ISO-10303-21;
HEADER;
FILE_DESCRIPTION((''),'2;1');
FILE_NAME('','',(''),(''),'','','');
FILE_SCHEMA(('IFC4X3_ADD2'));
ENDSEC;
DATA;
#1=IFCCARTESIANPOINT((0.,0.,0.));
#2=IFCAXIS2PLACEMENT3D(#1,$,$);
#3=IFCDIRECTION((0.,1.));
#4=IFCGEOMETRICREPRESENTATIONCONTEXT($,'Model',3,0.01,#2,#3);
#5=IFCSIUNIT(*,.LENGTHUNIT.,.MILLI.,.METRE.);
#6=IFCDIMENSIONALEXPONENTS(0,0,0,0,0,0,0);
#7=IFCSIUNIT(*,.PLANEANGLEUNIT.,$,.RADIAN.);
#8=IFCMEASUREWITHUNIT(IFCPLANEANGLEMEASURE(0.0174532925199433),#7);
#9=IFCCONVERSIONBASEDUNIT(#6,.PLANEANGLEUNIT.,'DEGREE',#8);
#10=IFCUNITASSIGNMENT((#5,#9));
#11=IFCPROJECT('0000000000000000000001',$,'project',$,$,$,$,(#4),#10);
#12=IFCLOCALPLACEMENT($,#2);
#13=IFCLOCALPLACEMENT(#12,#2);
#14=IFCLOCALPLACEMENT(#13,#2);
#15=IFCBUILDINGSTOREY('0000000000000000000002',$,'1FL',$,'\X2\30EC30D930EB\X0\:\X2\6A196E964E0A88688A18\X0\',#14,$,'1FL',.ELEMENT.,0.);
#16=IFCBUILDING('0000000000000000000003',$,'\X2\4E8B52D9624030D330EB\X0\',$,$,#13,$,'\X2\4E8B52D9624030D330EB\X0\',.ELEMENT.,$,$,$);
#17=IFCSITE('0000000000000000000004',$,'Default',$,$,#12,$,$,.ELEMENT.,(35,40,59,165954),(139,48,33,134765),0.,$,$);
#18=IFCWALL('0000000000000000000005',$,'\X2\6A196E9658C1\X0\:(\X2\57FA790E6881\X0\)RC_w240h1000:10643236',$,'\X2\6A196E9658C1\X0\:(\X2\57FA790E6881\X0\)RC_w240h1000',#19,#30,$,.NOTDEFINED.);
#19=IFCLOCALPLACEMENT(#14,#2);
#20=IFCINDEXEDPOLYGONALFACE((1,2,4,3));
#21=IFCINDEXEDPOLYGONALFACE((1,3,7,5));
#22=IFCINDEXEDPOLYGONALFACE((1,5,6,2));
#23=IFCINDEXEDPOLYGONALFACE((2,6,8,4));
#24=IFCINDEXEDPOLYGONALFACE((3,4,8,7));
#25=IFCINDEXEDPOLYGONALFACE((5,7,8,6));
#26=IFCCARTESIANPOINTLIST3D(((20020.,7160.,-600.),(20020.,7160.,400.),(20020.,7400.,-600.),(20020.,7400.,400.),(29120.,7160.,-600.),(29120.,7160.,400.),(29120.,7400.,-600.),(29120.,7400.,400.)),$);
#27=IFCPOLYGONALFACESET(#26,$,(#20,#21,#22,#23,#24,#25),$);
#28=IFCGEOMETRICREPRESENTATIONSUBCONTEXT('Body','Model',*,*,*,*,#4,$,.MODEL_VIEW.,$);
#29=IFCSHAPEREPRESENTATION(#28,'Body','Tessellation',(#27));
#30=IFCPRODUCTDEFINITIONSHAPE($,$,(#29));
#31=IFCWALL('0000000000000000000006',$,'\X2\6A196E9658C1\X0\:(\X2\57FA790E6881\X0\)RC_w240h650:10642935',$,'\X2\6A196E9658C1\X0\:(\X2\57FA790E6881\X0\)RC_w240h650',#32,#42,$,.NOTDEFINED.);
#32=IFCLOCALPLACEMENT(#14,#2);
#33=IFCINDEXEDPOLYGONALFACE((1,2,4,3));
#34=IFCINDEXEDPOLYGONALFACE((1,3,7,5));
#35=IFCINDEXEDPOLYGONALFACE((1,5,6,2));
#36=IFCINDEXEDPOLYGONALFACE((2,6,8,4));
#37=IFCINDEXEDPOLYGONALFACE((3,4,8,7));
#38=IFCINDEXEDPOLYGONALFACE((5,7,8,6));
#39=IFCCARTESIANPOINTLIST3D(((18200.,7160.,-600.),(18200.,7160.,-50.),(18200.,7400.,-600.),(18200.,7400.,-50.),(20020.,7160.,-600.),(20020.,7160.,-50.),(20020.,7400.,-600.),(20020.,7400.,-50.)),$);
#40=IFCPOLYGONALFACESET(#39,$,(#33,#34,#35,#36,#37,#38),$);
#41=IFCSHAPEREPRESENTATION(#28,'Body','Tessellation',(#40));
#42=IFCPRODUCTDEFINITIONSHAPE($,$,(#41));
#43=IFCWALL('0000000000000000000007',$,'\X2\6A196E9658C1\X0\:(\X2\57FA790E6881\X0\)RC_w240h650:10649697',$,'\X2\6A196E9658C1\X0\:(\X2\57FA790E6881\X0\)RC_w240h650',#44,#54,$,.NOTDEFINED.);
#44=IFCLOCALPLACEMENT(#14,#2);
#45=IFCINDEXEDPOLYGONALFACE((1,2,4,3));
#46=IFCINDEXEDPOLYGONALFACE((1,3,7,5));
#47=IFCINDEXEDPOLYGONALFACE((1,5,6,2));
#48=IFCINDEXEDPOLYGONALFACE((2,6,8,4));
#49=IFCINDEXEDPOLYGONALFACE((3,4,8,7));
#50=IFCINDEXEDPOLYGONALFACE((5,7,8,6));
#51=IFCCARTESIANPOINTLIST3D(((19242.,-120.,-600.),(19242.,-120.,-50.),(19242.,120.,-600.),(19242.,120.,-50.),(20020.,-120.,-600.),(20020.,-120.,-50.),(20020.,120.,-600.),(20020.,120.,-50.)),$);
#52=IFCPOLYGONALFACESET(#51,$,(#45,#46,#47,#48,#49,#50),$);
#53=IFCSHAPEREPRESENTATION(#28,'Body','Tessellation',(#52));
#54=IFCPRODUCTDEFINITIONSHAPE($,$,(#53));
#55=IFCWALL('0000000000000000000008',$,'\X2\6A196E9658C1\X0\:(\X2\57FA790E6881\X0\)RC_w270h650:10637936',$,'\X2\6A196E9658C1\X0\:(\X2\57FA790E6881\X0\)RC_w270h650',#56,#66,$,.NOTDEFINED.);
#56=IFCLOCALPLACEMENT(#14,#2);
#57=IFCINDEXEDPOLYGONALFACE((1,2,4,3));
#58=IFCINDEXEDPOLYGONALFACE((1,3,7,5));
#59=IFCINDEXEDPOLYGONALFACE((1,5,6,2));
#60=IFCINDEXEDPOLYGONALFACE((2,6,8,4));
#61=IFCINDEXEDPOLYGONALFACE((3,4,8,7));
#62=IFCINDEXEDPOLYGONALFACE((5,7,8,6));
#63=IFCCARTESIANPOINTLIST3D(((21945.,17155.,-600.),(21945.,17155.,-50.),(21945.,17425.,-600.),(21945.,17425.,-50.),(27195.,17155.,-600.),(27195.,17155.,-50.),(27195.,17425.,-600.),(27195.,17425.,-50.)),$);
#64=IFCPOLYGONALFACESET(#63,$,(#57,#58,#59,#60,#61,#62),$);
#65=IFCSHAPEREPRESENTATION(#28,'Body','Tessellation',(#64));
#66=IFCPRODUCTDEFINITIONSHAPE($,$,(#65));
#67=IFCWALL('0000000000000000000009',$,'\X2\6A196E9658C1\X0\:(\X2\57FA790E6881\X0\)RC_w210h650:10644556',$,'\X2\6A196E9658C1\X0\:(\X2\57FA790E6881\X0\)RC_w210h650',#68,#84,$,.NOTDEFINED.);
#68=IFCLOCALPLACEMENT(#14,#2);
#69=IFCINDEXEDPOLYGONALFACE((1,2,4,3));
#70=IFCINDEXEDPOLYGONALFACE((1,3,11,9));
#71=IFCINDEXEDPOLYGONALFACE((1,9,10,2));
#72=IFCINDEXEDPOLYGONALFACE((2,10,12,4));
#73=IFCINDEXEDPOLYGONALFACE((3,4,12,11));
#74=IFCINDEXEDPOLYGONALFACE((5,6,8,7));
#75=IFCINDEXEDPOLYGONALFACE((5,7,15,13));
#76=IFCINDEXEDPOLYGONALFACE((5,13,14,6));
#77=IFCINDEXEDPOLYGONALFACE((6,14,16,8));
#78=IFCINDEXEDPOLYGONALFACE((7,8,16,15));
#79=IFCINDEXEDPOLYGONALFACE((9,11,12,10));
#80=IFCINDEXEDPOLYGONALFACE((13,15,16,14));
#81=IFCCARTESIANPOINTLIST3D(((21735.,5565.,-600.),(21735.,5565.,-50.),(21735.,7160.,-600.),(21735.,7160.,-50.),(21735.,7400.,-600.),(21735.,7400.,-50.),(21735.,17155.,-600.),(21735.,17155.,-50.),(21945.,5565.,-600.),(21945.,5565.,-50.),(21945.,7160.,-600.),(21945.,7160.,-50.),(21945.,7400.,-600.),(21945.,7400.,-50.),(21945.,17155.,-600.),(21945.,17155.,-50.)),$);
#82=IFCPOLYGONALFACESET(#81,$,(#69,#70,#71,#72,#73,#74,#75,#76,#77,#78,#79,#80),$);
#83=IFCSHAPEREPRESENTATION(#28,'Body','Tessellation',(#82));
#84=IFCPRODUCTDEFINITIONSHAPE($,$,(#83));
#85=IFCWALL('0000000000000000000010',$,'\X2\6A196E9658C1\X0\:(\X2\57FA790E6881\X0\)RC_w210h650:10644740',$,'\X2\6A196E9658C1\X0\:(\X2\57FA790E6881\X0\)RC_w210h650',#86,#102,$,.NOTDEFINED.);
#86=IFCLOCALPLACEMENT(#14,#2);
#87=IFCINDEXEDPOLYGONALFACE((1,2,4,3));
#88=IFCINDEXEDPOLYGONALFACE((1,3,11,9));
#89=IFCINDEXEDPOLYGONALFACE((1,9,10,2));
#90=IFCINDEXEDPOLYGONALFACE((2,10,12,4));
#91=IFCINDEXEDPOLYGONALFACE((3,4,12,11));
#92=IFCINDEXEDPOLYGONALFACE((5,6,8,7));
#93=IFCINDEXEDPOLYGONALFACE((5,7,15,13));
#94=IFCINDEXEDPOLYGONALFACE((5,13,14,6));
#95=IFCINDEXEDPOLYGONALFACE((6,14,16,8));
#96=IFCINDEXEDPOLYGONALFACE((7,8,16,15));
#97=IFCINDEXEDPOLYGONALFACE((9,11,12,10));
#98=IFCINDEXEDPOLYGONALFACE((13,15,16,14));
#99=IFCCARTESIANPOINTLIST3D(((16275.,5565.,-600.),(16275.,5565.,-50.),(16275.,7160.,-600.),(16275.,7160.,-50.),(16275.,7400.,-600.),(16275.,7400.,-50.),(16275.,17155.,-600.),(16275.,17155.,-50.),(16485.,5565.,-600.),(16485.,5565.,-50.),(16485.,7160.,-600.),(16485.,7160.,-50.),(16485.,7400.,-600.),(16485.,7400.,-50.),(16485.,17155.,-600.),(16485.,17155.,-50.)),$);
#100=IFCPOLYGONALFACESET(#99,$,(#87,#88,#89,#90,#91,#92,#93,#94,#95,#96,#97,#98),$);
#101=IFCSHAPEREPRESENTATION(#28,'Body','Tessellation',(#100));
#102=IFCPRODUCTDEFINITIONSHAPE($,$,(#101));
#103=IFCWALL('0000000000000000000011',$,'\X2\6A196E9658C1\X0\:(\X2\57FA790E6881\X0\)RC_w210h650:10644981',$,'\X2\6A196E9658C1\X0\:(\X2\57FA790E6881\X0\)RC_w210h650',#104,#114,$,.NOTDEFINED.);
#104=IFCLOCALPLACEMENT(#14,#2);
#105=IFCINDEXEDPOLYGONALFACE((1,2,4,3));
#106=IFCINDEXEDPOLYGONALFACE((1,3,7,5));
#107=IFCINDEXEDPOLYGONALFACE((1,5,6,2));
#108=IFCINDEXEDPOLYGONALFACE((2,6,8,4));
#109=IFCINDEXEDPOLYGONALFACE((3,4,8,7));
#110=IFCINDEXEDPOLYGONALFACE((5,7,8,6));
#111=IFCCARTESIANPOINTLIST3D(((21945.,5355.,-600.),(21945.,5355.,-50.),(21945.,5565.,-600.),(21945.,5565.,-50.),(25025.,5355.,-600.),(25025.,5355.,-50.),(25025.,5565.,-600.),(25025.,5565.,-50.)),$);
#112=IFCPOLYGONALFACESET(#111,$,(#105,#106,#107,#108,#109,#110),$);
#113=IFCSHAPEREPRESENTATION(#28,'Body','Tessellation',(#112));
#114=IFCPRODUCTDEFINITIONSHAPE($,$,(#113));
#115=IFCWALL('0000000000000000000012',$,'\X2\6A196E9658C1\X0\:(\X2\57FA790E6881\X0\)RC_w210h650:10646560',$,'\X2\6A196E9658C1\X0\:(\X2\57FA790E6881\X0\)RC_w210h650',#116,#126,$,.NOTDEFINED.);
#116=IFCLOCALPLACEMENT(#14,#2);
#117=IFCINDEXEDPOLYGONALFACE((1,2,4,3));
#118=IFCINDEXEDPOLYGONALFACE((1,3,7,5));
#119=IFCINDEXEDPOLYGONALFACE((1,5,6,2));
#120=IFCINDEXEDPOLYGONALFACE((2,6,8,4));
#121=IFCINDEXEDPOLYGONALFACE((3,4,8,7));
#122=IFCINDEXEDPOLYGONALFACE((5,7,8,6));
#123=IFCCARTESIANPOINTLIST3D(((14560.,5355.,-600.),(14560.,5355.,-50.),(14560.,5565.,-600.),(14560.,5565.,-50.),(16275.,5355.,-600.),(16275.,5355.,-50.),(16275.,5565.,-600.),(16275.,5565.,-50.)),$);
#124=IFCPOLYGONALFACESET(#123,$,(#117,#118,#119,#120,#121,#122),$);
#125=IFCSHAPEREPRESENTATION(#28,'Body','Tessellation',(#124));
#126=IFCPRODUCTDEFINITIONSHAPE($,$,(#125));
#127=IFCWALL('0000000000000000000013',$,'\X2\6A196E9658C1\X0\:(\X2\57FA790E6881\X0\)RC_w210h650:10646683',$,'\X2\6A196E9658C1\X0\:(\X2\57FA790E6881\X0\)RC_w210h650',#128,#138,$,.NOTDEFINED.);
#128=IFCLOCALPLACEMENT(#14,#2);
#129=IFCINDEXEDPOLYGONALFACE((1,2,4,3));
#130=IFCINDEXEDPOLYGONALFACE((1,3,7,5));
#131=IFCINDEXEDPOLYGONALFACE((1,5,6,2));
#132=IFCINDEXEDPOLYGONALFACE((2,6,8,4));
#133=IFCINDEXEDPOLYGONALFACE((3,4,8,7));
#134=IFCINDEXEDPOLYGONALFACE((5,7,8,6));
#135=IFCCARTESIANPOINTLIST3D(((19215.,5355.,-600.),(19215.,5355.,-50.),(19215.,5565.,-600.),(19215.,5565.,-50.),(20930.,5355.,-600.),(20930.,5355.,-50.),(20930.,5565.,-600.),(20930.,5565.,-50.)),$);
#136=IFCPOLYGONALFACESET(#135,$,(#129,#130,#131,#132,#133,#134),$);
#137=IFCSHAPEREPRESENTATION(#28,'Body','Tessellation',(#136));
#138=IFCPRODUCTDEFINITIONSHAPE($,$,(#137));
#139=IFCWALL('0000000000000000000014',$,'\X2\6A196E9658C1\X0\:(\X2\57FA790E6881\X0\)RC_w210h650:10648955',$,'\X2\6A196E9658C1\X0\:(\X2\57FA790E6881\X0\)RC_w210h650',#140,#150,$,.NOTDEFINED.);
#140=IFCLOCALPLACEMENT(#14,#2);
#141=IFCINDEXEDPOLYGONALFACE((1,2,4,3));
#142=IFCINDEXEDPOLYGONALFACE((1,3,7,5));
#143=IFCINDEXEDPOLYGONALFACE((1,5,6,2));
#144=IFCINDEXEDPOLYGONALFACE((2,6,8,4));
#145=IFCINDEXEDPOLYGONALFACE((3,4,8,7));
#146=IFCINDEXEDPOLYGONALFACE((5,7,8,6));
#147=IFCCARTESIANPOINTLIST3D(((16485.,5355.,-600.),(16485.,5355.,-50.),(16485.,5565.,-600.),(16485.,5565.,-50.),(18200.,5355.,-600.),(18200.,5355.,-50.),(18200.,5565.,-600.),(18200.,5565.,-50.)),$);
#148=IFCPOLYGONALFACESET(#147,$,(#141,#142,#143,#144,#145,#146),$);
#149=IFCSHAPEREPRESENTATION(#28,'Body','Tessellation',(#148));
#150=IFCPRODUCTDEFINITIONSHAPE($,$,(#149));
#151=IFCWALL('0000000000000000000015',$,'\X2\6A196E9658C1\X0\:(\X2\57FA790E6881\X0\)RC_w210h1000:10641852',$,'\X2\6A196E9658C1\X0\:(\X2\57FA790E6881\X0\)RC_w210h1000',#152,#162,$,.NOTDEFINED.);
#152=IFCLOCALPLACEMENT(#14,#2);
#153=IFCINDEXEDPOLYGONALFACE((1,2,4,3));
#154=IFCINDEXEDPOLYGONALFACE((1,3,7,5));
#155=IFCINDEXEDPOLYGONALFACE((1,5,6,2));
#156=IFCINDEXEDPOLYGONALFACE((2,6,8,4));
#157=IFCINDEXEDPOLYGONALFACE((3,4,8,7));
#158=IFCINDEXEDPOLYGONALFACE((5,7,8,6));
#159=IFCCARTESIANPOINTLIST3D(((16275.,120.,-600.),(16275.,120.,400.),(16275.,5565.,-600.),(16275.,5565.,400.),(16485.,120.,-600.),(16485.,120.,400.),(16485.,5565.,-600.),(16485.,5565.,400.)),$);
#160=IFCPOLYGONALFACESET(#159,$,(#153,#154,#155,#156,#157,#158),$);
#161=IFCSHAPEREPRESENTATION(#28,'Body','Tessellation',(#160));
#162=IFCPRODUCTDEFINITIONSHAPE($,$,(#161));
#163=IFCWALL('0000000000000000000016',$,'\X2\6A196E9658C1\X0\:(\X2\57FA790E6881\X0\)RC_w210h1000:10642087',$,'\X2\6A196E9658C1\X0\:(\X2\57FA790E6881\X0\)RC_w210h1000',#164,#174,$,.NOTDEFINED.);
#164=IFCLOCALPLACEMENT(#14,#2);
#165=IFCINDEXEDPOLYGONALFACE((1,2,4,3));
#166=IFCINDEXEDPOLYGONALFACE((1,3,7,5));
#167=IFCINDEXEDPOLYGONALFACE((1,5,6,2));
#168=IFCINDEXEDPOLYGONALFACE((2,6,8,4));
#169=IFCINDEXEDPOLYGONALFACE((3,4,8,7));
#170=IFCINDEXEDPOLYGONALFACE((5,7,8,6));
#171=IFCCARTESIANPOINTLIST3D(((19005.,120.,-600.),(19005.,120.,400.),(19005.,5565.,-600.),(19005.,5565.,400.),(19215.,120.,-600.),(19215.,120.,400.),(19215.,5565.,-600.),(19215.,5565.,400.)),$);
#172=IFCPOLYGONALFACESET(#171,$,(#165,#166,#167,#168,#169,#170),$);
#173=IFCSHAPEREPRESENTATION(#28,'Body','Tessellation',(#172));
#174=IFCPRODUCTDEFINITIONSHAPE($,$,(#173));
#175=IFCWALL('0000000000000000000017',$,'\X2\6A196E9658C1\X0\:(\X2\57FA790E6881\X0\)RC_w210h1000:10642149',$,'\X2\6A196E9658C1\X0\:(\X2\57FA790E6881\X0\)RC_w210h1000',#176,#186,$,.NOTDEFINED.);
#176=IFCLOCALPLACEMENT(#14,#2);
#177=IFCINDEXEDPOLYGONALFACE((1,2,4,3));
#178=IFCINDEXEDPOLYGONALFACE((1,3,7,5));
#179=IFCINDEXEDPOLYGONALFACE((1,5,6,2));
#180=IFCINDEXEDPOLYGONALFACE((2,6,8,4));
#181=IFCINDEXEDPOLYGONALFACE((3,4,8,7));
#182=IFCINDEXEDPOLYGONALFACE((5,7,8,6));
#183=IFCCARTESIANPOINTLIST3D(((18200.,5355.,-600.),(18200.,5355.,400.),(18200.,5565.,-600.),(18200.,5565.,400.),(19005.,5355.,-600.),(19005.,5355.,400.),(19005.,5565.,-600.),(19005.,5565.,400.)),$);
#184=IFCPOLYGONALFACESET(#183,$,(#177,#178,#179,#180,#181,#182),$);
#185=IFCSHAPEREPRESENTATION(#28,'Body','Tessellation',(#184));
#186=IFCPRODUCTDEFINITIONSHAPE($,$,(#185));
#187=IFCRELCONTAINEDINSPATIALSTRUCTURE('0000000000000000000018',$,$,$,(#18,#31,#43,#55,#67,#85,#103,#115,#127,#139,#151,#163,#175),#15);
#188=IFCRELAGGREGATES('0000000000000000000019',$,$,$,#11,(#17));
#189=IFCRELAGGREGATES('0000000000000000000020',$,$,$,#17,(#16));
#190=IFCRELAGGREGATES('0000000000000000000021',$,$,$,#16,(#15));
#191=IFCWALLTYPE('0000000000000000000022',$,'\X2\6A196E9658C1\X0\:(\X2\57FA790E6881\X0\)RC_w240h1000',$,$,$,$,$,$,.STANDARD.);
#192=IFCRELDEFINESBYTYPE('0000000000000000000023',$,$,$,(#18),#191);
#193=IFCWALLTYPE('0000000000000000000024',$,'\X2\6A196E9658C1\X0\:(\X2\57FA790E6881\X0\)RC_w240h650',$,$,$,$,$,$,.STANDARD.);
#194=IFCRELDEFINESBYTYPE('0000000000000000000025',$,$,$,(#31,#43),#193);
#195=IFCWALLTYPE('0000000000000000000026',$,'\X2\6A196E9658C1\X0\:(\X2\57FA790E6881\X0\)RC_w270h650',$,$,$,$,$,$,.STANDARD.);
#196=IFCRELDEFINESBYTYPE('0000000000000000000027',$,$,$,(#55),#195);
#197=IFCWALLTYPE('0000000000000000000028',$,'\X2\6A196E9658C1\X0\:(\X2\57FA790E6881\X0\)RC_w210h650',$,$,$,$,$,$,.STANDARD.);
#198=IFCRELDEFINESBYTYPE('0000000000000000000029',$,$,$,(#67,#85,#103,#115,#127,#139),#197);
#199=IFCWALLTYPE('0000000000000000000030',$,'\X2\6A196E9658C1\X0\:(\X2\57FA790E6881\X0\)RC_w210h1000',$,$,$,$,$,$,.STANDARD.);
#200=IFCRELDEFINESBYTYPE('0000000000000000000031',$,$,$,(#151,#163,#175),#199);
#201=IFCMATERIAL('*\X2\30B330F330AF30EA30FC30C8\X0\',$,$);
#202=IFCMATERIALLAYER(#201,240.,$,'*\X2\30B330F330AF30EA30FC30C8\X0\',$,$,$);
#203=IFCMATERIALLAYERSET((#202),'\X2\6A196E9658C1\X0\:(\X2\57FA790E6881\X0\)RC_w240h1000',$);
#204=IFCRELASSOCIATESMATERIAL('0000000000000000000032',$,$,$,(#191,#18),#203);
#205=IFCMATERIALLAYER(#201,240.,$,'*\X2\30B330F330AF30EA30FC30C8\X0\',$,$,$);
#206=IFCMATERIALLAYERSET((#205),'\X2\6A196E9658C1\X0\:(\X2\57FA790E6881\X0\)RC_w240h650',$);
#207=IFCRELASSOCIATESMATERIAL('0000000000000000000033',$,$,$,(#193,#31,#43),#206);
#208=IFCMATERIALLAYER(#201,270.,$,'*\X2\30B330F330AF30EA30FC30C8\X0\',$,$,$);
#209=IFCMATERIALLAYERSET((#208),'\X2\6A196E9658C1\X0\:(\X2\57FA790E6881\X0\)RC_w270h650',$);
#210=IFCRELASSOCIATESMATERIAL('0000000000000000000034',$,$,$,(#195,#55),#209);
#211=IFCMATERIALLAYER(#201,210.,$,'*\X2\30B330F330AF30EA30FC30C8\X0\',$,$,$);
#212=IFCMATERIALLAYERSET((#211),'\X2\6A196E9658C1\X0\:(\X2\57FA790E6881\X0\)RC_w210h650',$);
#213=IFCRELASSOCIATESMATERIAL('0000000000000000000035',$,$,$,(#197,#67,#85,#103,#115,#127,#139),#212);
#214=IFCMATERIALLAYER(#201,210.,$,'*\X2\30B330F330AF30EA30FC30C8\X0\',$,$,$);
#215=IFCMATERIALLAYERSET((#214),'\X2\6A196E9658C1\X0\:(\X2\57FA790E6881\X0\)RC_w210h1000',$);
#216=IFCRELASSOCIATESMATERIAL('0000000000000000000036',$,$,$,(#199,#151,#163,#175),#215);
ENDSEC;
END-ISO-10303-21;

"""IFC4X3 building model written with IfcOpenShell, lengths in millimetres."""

from ifc_helpers import new_model, entity, si_unit, converted_unit, direction, frame, frame_2d, origin, origin_2d_with_axis, place, context, subcontext, project, spatial, rectangle, extrude, material, layer, layer_set, type_object, element, save


model = new_model("IFC4X3")

# Units and contexts
model_context = context("Model", 3, precision=0.01, world=origin(), true_north=direction((0.0, 1.0)))
body_context = subcontext(model_context, "Body", "Model", "MODEL_VIEW")
ifc_project = project(units=[si_unit("LENGTHUNIT", "METRE", prefix="MILLI"), converted_unit("PLANEANGLEUNIT", "DEGREE", entity("IfcPlaneAngleMeasure", 0.0174532925199433), si_unit("PLANEANGLEUNIT", "RADIAN"), dimensions=[0, 0, 0, 0, 0, 0, 0])], contexts=[model_context])

# Site, building, storey
site_placement = place(None, origin())
site = spatial("IfcSite", under=ifc_project, at=site_placement, Name="Default", CompositionType="ELEMENT", RefLatitude=(35, 40, 59, 165954), RefLongitude=(139, 48, 33, 134765), RefElevation=0.0)
building_placement = place(site_placement, origin())
building = spatial("IfcBuilding", under=site, at=building_placement, Name="事務所ビル", LongName="事務所ビル", CompositionType="ELEMENT")
storey_placement = place(building_placement, origin())
storey = spatial("IfcBuildingStorey", under=building, at=storey_placement, Name="1FL", ObjectType="レベル:標準上表記", LongName="1FL", CompositionType="ELEMENT", Elevation=0.0)

# Shared definitions
ifc_material_1 = material(Name="*コンクリート")
ifc_layer_1 = layer(ifc_material_1, 240.0, Name="*コンクリート")
ifc_layer_set_1 = layer_set([ifc_layer_1], Name="標準壁:(基礎梁)RC_w240h1000")
wall_type_1 = type_object("IfcWallType", Name="標準壁:(基礎梁)RC_w240h1000", PredefinedType="STANDARD", material=ifc_layer_set_1)

# Walls
wall_1_placement = place(storey_placement, frame((20020.0, 7280.0, -600.0)))
element("IfcWall", 1, at=wall_1_placement, inside=storey, type_object=wall_type_1, material=ifc_layer_set_1, Name="標準壁:(基礎梁)RC_w240h1000:10643236", ObjectType="標準壁:(基礎梁)RC_w240h1000", PredefinedType="NOTDEFINED", context=body_context, shape_type="SweptSolid", body=[
    extrude(rectangle(XDim=9100.0, YDim=240.0, at=frame_2d((4550.0, 0.0), x_axis=(-1.0, 0.0))), origin(), (0.0, 0.0, 1.0), 1000.0),
])
ifc_layer_2 = layer(ifc_material_1, 240.0, Name="*コンクリート")
ifc_layer_set_2 = layer_set([ifc_layer_2], Name="標準壁:(基礎梁)RC_w240h650")
wall_type_2 = type_object("IfcWallType", Name="標準壁:(基礎梁)RC_w240h650", PredefinedType="STANDARD", material=ifc_layer_set_2)
wall_2_placement = place(storey_placement, frame((18200.0, 7280.0, -600.0)))
element("IfcWall", 2, at=wall_2_placement, inside=storey, type_object=wall_type_2, material=ifc_layer_set_2, Name="標準壁:(基礎梁)RC_w240h650:10642935", ObjectType="標準壁:(基礎梁)RC_w240h650", PredefinedType="NOTDEFINED", context=body_context, shape_type="SweptSolid", body=[
    extrude(rectangle(XDim=1820.0, YDim=240.0, at=frame_2d((910.0, 0.0), x_axis=(-1.0, 0.0))), origin(), (0.0, 0.0, 1.0), 550.0),
])
wall_3_placement = place(storey_placement, frame((19242.0, 0.0, -600.0)))
element("IfcWall", 3, at=wall_3_placement, inside=storey, type_object=wall_type_2, material=ifc_layer_set_2, Name="標準壁:(基礎梁)RC_w240h650:10649697", ObjectType="標準壁:(基礎梁)RC_w240h650", PredefinedType="NOTDEFINED", context=body_context, shape_type="SweptSolid", body=[
    extrude(rectangle(XDim=778.0, YDim=240.0, at=frame_2d((389.0, 0.0), x_axis=(-1.0, 0.0))), origin(), (0.0, 0.0, 1.0), 550.0),
])
ifc_layer_3 = layer(ifc_material_1, 270.0, Name="*コンクリート")
ifc_layer_set_3 = layer_set([ifc_layer_3], Name="標準壁:(基礎梁)RC_w270h650")
wall_type_3 = type_object("IfcWallType", Name="標準壁:(基礎梁)RC_w270h650", PredefinedType="STANDARD", material=ifc_layer_set_3)
wall_4_placement = place(storey_placement, frame((21945.0, 17290.0, -600.0)))
element("IfcWall", 4, at=wall_4_placement, inside=storey, type_object=wall_type_3, material=ifc_layer_set_3, Name="標準壁:(基礎梁)RC_w270h650:10637936", ObjectType="標準壁:(基礎梁)RC_w270h650", PredefinedType="NOTDEFINED", context=body_context, shape_type="SweptSolid", body=[
    extrude(rectangle(XDim=5250.0, YDim=270.0, at=frame_2d((2625.0, 0.0), x_axis=(-1.0, 0.0))), origin(), (0.0, 0.0, 1.0), 550.0),
])

# Walls, openings
ifc_layer_4 = layer(ifc_material_1, 210.0, Name="*コンクリート")
ifc_layer_set_4 = layer_set([ifc_layer_4], Name="標準壁:(基礎梁)RC_w210h650")
wall_type_4 = type_object("IfcWallType", Name="標準壁:(基礎梁)RC_w210h650", PredefinedType="STANDARD", material=ifc_layer_set_4)
wall_5_placement = place(storey_placement, frame((21840.0, 5565.0, -600.0), z_axis=(0.0, 0.0, 1.0), x_axis=(0.0, 1.0, 0.0)))
wall_5 = element("IfcWall", 5, at=wall_5_placement, inside=storey, type_object=wall_type_4, material=ifc_layer_set_4, Name="標準壁:(基礎梁)RC_w210h650:10644556", ObjectType="標準壁:(基礎梁)RC_w210h650", PredefinedType="NOTDEFINED", context=body_context, shape_type="SweptSolid", body=[
    extrude(rectangle(XDim=11590.0, YDim=210.0, at=frame_2d((5795.0, 0.0), x_axis=(-1.0, 0.0))), origin(), (0.0, 0.0, 1.0), 550.0),
])
opening_1_placement = place(storey_placement, frame((21840.0, 5565.0, -600.0), z_axis=(0.0, 0.0, 1.0), x_axis=(0.0, 1.0, 0.0)))
element("IfcOpeningElement", 6, at=opening_1_placement, cuts=wall_5, PredefinedType="OPENING", context=body_context, shape_type="SweptSolid", body=[
    extrude(rectangle(XDim=550.0, YDim=210.0, at=frame_2d((0.0, 0.0), x_axis=(1.0, 0.0))), frame((1595.0, 0.0, 275.0), z_axis=(1.0, 0.0, 0.0), x_axis=(0.0, 0.0, -1.0)), (0.0, 0.0, 1.0), 240.0),
])
wall_6_placement = place(storey_placement, frame((16380.0, 5565.0, -600.0), z_axis=(0.0, 0.0, 1.0), x_axis=(0.0, 1.0, 0.0)))
wall_6 = element("IfcWall", 7, at=wall_6_placement, inside=storey, type_object=wall_type_4, material=ifc_layer_set_4, Name="標準壁:(基礎梁)RC_w210h650:10644740", ObjectType="標準壁:(基礎梁)RC_w210h650", PredefinedType="NOTDEFINED", context=body_context, shape_type="SweptSolid", body=[
    extrude(rectangle(XDim=11590.0, YDim=210.0, at=frame_2d((5795.0, 0.0), x_axis=(-1.0, 0.0))), origin(), (0.0, 0.0, 1.0), 550.0),
])
opening_2_placement = place(storey_placement, frame((16380.0, 5565.0, -600.0), z_axis=(0.0, 0.0, 1.0), x_axis=(0.0, 1.0, 0.0)))
element("IfcOpeningElement", 8, at=opening_2_placement, cuts=wall_6, PredefinedType="OPENING", context=body_context, shape_type="SweptSolid", body=[
    extrude(rectangle(XDim=550.0, YDim=210.0, at=origin_2d_with_axis()), frame((1595.0, 0.0, 275.0), z_axis=(1.0, 0.0, 0.0), x_axis=(0.0, 0.0, -1.0)), (0.0, 0.0, 1.0), 240.0),
])

# Walls
wall_7_placement = place(storey_placement, frame((21945.0, 5460.0, -600.0)))
element("IfcWall", 9, at=wall_7_placement, inside=storey, type_object=wall_type_4, material=ifc_layer_set_4, Name="標準壁:(基礎梁)RC_w210h650:10644981", ObjectType="標準壁:(基礎梁)RC_w210h650", PredefinedType="NOTDEFINED", context=body_context, shape_type="SweptSolid", body=[
    extrude(rectangle(XDim=3080.0, YDim=210.0, at=frame_2d((1540.0, 0.0), x_axis=(-1.0, 0.0))), origin(), (0.0, 0.0, 1.0), 550.0),
])
wall_8_placement = place(storey_placement, frame((14560.0, 5460.0, -600.0)))
element("IfcWall", 10, at=wall_8_placement, inside=storey, type_object=wall_type_4, material=ifc_layer_set_4, Name="標準壁:(基礎梁)RC_w210h650:10646560", ObjectType="標準壁:(基礎梁)RC_w210h650", PredefinedType="NOTDEFINED", context=body_context, shape_type="SweptSolid", body=[
    extrude(rectangle(XDim=1715.0, YDim=210.0, at=frame_2d((857.5, 0.0), x_axis=(-1.0, 0.0))), origin(), (0.0, 0.0, 1.0), 550.0),
])
wall_9_placement = place(storey_placement, frame((19215.0, 5460.0, -600.0)))
element("IfcWall", 11, at=wall_9_placement, inside=storey, type_object=wall_type_4, material=ifc_layer_set_4, Name="標準壁:(基礎梁)RC_w210h650:10646683", ObjectType="標準壁:(基礎梁)RC_w210h650", PredefinedType="NOTDEFINED", context=body_context, shape_type="SweptSolid", body=[
    extrude(rectangle(XDim=1715.0, YDim=210.0, at=frame_2d((857.5, 0.0), x_axis=(-1.0, 0.0))), origin(), (0.0, 0.0, 1.0), 550.0),
])
wall_10_placement = place(storey_placement, frame((16485.0, 5460.0, -600.0)))
element("IfcWall", 12, at=wall_10_placement, inside=storey, type_object=wall_type_4, material=ifc_layer_set_4, Name="標準壁:(基礎梁)RC_w210h650:10648955", ObjectType="標準壁:(基礎梁)RC_w210h650", PredefinedType="NOTDEFINED", context=body_context, shape_type="SweptSolid", body=[
    extrude(rectangle(XDim=1715.0, YDim=210.0, at=frame_2d((857.5, 0.0), x_axis=(-1.0, 0.0))), origin(), (0.0, 0.0, 1.0), 550.0),
])
ifc_layer_5 = layer(ifc_material_1, 210.0, Name="*コンクリート")
ifc_layer_set_5 = layer_set([ifc_layer_5], Name="標準壁:(基礎梁)RC_w210h1000")
wall_type_5 = type_object("IfcWallType", Name="標準壁:(基礎梁)RC_w210h1000", PredefinedType="STANDARD", material=ifc_layer_set_5)
for number, where, z_axis, x_axis, name in (
    (13, (16380.0, 120.0, -600.0), (0.0, 0.0, 1.0), (0.0, 1.0, 0.0), "標準壁:(基礎梁)RC_w210h1000:10641852"),
    (14, (19110.0, 120.0, -600.0), (0.0, 0.0, 1.0), (0.0, 1.0, 0.0), "標準壁:(基礎梁)RC_w210h1000:10642087"),
):
    element("IfcWall", number, at=place(storey_placement, frame(where, z_axis=z_axis, x_axis=x_axis)), inside=storey, type_object=wall_type_5, material=ifc_layer_set_5, Name=name, ObjectType="標準壁:(基礎梁)RC_w210h1000", PredefinedType="NOTDEFINED", context=body_context, shape_type="SweptSolid", body=[
        extrude(rectangle(XDim=5445.0, YDim=210.0, at=frame_2d((2722.5, 0.0), x_axis=(-1.0, 0.0))), origin(), (0.0, 0.0, 1.0), 1000.0),
    ])
wall_11_placement = place(storey_placement, frame((19005.0, 5460.0, -600.0), z_axis=(0.0, 0.0, 1.0), x_axis=(-1.0, 0.0, 0.0)))
element("IfcWall", 15, at=wall_11_placement, inside=storey, type_object=wall_type_5, material=ifc_layer_set_5, Name="標準壁:(基礎梁)RC_w210h1000:10642149", ObjectType="標準壁:(基礎梁)RC_w210h1000", PredefinedType="NOTDEFINED", context=body_context, shape_type="SweptSolid", body=[
    extrude(rectangle(XDim=805.0, YDim=210.0, at=frame_2d((402.5, 0.0), x_axis=(-1.0, 0.0))), origin(), (0.0, 0.0, 1.0), 1000.0),
])

save(model, "model.ifc")
